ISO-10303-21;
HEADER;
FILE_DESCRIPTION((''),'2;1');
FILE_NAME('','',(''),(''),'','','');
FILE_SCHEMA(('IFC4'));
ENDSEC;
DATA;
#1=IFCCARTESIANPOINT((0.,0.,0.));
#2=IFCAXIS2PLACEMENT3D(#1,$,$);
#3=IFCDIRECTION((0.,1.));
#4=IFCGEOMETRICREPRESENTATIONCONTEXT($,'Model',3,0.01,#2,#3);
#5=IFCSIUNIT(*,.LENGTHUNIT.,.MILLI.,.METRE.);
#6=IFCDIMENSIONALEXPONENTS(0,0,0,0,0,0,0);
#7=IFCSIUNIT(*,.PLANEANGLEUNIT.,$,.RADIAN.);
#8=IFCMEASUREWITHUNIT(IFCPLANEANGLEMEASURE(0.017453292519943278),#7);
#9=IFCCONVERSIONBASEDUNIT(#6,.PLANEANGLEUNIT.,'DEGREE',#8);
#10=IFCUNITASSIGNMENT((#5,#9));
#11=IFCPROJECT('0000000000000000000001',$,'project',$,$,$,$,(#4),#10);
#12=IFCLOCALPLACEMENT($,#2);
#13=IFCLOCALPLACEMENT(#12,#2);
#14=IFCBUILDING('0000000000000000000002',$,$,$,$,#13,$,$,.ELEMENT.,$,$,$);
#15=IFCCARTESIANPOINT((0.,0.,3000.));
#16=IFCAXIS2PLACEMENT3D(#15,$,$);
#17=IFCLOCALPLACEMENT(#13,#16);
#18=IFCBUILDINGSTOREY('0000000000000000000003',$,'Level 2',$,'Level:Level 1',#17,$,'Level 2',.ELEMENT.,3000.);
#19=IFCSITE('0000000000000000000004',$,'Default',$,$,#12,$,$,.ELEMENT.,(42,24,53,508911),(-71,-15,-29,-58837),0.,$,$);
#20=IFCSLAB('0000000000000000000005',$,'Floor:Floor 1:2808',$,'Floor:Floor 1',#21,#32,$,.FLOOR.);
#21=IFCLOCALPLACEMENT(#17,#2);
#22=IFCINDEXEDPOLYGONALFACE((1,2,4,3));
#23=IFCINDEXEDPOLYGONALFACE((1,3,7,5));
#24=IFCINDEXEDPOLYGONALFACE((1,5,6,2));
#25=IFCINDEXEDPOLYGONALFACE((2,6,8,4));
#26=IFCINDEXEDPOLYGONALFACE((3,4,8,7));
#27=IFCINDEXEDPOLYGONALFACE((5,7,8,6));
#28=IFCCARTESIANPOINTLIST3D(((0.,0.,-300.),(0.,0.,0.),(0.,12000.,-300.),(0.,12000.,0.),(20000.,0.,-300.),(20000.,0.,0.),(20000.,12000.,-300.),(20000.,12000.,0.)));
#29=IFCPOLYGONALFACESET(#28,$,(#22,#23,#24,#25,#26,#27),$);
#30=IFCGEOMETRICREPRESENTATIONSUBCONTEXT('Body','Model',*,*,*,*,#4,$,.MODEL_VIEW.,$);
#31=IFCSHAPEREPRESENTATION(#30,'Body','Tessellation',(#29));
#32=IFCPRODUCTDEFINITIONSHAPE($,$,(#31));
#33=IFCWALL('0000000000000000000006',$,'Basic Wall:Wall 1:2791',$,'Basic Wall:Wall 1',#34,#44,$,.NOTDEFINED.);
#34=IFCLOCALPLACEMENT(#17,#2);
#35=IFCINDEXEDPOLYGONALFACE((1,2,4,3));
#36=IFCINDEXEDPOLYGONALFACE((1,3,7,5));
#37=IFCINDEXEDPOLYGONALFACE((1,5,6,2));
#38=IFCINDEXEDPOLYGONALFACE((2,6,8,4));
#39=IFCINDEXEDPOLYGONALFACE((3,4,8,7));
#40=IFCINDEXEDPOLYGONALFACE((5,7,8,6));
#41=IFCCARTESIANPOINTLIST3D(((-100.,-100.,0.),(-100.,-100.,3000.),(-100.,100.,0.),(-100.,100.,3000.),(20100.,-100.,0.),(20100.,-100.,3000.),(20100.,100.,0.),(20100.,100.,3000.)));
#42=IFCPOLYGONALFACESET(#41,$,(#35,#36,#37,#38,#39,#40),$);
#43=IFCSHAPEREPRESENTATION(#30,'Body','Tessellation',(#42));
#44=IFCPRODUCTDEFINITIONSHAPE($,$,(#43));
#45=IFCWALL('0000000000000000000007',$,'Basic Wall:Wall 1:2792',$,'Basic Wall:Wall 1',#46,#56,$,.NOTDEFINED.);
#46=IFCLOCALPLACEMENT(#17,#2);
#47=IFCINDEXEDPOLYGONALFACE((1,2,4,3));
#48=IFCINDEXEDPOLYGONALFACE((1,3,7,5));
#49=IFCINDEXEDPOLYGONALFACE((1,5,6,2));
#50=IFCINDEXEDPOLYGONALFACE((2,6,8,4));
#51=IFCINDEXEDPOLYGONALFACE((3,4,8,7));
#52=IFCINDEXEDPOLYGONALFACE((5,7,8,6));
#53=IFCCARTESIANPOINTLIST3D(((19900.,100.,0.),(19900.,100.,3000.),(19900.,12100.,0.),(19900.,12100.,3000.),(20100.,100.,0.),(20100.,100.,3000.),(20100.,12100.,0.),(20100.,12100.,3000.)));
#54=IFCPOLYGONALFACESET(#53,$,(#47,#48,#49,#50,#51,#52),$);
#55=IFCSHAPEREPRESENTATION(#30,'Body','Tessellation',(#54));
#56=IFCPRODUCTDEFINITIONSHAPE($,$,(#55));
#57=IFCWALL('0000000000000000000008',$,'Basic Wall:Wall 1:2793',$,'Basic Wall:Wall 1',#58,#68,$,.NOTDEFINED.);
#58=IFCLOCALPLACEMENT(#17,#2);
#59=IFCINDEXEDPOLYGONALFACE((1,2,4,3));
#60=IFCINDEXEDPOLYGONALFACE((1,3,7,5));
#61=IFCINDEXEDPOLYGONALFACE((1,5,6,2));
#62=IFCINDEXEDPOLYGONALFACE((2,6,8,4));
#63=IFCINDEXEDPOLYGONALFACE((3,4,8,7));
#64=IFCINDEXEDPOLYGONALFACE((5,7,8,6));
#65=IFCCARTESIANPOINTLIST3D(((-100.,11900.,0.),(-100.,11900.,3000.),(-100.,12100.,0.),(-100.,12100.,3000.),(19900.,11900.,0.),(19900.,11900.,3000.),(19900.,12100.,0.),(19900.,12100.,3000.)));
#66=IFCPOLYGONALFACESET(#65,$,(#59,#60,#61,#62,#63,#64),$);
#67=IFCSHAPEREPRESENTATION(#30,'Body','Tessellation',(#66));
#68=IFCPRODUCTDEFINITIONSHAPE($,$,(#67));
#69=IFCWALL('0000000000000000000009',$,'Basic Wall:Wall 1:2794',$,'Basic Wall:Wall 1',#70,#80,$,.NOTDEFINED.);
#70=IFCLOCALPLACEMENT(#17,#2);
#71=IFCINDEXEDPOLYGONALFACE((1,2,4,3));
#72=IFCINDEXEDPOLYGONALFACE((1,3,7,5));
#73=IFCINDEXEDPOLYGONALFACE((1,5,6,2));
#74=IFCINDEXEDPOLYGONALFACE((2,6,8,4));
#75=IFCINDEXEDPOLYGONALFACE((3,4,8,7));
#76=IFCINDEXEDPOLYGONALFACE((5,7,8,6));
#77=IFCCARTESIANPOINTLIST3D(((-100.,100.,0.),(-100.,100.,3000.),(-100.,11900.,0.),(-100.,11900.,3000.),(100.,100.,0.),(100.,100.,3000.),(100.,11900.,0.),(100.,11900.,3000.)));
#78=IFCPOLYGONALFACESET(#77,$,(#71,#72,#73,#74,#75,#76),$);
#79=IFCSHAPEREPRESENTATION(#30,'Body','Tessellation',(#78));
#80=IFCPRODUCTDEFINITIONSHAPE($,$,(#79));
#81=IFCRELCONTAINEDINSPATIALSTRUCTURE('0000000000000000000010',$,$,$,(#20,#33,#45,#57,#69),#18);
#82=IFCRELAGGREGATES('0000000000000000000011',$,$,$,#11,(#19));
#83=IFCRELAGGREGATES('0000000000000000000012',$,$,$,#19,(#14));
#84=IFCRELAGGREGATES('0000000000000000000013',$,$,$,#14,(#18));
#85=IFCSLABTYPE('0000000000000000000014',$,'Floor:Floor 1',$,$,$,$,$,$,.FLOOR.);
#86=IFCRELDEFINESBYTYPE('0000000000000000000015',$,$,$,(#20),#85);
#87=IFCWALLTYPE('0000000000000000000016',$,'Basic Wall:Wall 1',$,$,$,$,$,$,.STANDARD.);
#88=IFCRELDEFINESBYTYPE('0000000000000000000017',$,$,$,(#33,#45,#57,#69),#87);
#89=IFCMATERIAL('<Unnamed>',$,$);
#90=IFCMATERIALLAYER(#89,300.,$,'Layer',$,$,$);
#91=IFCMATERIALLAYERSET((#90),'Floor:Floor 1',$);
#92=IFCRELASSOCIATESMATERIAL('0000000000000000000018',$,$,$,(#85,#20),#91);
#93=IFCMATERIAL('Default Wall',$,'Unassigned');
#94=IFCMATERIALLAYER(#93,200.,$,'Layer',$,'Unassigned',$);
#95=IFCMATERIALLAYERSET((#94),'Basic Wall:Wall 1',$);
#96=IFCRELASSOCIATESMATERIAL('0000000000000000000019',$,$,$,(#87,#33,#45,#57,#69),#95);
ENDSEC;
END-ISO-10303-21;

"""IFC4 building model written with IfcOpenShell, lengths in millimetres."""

from ifc_helpers import new_model, entity, si_unit, converted_unit, direction, frame, frame_2d, origin, origin_2d_with_axis, place, context, subcontext, project, spatial, rectangle, extrude, material, layer, layer_set, layer_usage, type_object, element, save


model = new_model("IFC4")

# Units and contexts
model_context = context("Model", 3, precision=0.01, world=origin(), true_north=direction((0.0, 1.0)))
body_context = subcontext(model_context, "Body", "Model", "MODEL_VIEW")
ifc_project = project(units=[si_unit("LENGTHUNIT", "METRE", prefix="MILLI"), converted_unit("PLANEANGLEUNIT", "DEGREE", entity("IfcPlaneAngleMeasure", 0.017453292519943278), si_unit("PLANEANGLEUNIT", "RADIAN"), dimensions=[0, 0, 0, 0, 0, 0, 0])], contexts=[model_context])

# Site, building, storey
site_placement = place(None, origin())
site = spatial("IfcSite", under=ifc_project, at=site_placement, Name="Default", CompositionType="ELEMENT", RefLatitude=(42, 24, 53, 508911), RefLongitude=(-71, -15, -29, -58837), RefElevation=0.0)
building_placement = place(site_placement, origin())
building = spatial("IfcBuilding", under=site, at=building_placement, CompositionType="ELEMENT")
storey_placement = place(building_placement, frame((0.0, 0.0, 3000.0)))
storey = spatial("IfcBuildingStorey", under=building, at=storey_placement, Name="Level 2", ObjectType="Level:Level 1", LongName="Level 2", CompositionType="ELEMENT", Elevation=3000.0)

# Slab
ifc_material_1 = material(Name="<Unnamed>")
ifc_layer_1 = layer(ifc_material_1, 300.0, Name="Layer")
ifc_layer_set_1 = layer_set([ifc_layer_1], Name="Floor:Floor 1")
ifc_layer_usage_1 = layer_usage(ifc_layer_set_1, "AXIS3", "POSITIVE", 0.0)
slab_type = type_object("IfcSlabType", Name="Floor:Floor 1", PredefinedType="FLOOR", material=ifc_layer_set_1)
slab_placement = place(storey_placement, origin())
element("IfcSlab", 1, at=slab_placement, inside=storey, type_object=slab_type, material=ifc_layer_usage_1, Name="Floor:Floor 1:2808", ObjectType="Floor:Floor 1", PredefinedType="FLOOR", context=body_context, shape_type="SweptSolid", body=[
    extrude(rectangle(XDim=12000.0, YDim=20000.0, at=origin_2d_with_axis()), frame((10000.0, 6000.0, 0.0), z_axis=(0.0, 0.0, -1.0), x_axis=(0.0, 1.0, 0.0)), (0.0, 0.0, 1.0), 300.0),
])

# Walls
ifc_material_2 = material(Name="Default Wall", Category="Unassigned")
ifc_layer_2 = layer(ifc_material_2, 200.0, Name="Layer", Category="Unassigned")
ifc_layer_set_2 = layer_set([ifc_layer_2], Name="Basic Wall:Wall 1")
ifc_layer_usage_2 = layer_usage(ifc_layer_set_2, "AXIS2", "NEGATIVE", 100.0)
wall_type = type_object("IfcWallType", Name="Basic Wall:Wall 1", PredefinedType="STANDARD", material=ifc_layer_set_2)
wall_1_placement = place(storey_placement, frame((-100.0, 0.0, 0.0)))
element("IfcWall", 2, at=wall_1_placement, inside=storey, type_object=wall_type, material=ifc_layer_usage_2, Name="Basic Wall:Wall 1:2791", ObjectType="Basic Wall:Wall 1", PredefinedType="NOTDEFINED", context=body_context, shape_type="SweptSolid", body=[
    extrude(rectangle(XDim=20200.0, YDim=200.0, at=frame_2d((10100.0, 0.0), x_axis=(-1.0, 0.0))), origin(), (0.0, 0.0, 1.0), 3000.0),
])
ifc_layer_usage_3 = layer_usage(ifc_layer_set_2, "AXIS2", "NEGATIVE", 100.0)
wall_2_placement = place(storey_placement, frame((20000.0, 100.0, 0.0), z_axis=(0.0, 0.0, 1.0), x_axis=(0.0, 1.0, 0.0)))
element("IfcWall", 3, at=wall_2_placement, inside=storey, type_object=wall_type, material=ifc_layer_usage_3, Name="Basic Wall:Wall 1:2792", ObjectType="Basic Wall:Wall 1", PredefinedType="NOTDEFINED", context=body_context, shape_type="SweptSolid", body=[
    extrude(rectangle(XDim=12000.0, YDim=200.0, at=frame_2d((6000.0, 0.0), x_axis=(-1.0, 0.0))), origin(), (0.0, 0.0, 1.0), 3000.0),
])
ifc_layer_usage_4 = layer_usage(ifc_layer_set_2, "AXIS2", "NEGATIVE", 100.0)
wall_3_placement = place(storey_placement, frame((19900.0, 12000.0, 0.0), z_axis=(0.0, 0.0, 1.0), x_axis=(-1.0, 0.0, 0.0)))
element("IfcWall", 4, at=wall_3_placement, inside=storey, type_object=wall_type, material=ifc_layer_usage_4, Name="Basic Wall:Wall 1:2793", ObjectType="Basic Wall:Wall 1", PredefinedType="NOTDEFINED", context=body_context, shape_type="SweptSolid", body=[
    extrude(rectangle(XDim=20000.0, YDim=200.0, at=frame_2d((10000.0, 0.0), x_axis=(-1.0, 0.0))), origin(), (0.0, 0.0, 1.0), 3000.0),
])
ifc_layer_usage_5 = layer_usage(ifc_layer_set_2, "AXIS2", "NEGATIVE", 100.0)
wall_4_placement = place(storey_placement, frame((0.0, 11900.0, 0.0), z_axis=(0.0, 0.0, 1.0), x_axis=(0.0, -1.0, 0.0)))
element("IfcWall", 5, at=wall_4_placement, inside=storey, type_object=wall_type, material=ifc_layer_usage_5, Name="Basic Wall:Wall 1:2794", ObjectType="Basic Wall:Wall 1", PredefinedType="NOTDEFINED", context=body_context, shape_type="SweptSolid", body=[
    extrude(rectangle(XDim=11800.0, YDim=200.0, at=frame_2d((5900.0, 0.0), x_axis=(-1.0, 0.0))), origin(), (0.0, 0.0, 1.0), 3000.0),
])

save(model, "model.ifc")
